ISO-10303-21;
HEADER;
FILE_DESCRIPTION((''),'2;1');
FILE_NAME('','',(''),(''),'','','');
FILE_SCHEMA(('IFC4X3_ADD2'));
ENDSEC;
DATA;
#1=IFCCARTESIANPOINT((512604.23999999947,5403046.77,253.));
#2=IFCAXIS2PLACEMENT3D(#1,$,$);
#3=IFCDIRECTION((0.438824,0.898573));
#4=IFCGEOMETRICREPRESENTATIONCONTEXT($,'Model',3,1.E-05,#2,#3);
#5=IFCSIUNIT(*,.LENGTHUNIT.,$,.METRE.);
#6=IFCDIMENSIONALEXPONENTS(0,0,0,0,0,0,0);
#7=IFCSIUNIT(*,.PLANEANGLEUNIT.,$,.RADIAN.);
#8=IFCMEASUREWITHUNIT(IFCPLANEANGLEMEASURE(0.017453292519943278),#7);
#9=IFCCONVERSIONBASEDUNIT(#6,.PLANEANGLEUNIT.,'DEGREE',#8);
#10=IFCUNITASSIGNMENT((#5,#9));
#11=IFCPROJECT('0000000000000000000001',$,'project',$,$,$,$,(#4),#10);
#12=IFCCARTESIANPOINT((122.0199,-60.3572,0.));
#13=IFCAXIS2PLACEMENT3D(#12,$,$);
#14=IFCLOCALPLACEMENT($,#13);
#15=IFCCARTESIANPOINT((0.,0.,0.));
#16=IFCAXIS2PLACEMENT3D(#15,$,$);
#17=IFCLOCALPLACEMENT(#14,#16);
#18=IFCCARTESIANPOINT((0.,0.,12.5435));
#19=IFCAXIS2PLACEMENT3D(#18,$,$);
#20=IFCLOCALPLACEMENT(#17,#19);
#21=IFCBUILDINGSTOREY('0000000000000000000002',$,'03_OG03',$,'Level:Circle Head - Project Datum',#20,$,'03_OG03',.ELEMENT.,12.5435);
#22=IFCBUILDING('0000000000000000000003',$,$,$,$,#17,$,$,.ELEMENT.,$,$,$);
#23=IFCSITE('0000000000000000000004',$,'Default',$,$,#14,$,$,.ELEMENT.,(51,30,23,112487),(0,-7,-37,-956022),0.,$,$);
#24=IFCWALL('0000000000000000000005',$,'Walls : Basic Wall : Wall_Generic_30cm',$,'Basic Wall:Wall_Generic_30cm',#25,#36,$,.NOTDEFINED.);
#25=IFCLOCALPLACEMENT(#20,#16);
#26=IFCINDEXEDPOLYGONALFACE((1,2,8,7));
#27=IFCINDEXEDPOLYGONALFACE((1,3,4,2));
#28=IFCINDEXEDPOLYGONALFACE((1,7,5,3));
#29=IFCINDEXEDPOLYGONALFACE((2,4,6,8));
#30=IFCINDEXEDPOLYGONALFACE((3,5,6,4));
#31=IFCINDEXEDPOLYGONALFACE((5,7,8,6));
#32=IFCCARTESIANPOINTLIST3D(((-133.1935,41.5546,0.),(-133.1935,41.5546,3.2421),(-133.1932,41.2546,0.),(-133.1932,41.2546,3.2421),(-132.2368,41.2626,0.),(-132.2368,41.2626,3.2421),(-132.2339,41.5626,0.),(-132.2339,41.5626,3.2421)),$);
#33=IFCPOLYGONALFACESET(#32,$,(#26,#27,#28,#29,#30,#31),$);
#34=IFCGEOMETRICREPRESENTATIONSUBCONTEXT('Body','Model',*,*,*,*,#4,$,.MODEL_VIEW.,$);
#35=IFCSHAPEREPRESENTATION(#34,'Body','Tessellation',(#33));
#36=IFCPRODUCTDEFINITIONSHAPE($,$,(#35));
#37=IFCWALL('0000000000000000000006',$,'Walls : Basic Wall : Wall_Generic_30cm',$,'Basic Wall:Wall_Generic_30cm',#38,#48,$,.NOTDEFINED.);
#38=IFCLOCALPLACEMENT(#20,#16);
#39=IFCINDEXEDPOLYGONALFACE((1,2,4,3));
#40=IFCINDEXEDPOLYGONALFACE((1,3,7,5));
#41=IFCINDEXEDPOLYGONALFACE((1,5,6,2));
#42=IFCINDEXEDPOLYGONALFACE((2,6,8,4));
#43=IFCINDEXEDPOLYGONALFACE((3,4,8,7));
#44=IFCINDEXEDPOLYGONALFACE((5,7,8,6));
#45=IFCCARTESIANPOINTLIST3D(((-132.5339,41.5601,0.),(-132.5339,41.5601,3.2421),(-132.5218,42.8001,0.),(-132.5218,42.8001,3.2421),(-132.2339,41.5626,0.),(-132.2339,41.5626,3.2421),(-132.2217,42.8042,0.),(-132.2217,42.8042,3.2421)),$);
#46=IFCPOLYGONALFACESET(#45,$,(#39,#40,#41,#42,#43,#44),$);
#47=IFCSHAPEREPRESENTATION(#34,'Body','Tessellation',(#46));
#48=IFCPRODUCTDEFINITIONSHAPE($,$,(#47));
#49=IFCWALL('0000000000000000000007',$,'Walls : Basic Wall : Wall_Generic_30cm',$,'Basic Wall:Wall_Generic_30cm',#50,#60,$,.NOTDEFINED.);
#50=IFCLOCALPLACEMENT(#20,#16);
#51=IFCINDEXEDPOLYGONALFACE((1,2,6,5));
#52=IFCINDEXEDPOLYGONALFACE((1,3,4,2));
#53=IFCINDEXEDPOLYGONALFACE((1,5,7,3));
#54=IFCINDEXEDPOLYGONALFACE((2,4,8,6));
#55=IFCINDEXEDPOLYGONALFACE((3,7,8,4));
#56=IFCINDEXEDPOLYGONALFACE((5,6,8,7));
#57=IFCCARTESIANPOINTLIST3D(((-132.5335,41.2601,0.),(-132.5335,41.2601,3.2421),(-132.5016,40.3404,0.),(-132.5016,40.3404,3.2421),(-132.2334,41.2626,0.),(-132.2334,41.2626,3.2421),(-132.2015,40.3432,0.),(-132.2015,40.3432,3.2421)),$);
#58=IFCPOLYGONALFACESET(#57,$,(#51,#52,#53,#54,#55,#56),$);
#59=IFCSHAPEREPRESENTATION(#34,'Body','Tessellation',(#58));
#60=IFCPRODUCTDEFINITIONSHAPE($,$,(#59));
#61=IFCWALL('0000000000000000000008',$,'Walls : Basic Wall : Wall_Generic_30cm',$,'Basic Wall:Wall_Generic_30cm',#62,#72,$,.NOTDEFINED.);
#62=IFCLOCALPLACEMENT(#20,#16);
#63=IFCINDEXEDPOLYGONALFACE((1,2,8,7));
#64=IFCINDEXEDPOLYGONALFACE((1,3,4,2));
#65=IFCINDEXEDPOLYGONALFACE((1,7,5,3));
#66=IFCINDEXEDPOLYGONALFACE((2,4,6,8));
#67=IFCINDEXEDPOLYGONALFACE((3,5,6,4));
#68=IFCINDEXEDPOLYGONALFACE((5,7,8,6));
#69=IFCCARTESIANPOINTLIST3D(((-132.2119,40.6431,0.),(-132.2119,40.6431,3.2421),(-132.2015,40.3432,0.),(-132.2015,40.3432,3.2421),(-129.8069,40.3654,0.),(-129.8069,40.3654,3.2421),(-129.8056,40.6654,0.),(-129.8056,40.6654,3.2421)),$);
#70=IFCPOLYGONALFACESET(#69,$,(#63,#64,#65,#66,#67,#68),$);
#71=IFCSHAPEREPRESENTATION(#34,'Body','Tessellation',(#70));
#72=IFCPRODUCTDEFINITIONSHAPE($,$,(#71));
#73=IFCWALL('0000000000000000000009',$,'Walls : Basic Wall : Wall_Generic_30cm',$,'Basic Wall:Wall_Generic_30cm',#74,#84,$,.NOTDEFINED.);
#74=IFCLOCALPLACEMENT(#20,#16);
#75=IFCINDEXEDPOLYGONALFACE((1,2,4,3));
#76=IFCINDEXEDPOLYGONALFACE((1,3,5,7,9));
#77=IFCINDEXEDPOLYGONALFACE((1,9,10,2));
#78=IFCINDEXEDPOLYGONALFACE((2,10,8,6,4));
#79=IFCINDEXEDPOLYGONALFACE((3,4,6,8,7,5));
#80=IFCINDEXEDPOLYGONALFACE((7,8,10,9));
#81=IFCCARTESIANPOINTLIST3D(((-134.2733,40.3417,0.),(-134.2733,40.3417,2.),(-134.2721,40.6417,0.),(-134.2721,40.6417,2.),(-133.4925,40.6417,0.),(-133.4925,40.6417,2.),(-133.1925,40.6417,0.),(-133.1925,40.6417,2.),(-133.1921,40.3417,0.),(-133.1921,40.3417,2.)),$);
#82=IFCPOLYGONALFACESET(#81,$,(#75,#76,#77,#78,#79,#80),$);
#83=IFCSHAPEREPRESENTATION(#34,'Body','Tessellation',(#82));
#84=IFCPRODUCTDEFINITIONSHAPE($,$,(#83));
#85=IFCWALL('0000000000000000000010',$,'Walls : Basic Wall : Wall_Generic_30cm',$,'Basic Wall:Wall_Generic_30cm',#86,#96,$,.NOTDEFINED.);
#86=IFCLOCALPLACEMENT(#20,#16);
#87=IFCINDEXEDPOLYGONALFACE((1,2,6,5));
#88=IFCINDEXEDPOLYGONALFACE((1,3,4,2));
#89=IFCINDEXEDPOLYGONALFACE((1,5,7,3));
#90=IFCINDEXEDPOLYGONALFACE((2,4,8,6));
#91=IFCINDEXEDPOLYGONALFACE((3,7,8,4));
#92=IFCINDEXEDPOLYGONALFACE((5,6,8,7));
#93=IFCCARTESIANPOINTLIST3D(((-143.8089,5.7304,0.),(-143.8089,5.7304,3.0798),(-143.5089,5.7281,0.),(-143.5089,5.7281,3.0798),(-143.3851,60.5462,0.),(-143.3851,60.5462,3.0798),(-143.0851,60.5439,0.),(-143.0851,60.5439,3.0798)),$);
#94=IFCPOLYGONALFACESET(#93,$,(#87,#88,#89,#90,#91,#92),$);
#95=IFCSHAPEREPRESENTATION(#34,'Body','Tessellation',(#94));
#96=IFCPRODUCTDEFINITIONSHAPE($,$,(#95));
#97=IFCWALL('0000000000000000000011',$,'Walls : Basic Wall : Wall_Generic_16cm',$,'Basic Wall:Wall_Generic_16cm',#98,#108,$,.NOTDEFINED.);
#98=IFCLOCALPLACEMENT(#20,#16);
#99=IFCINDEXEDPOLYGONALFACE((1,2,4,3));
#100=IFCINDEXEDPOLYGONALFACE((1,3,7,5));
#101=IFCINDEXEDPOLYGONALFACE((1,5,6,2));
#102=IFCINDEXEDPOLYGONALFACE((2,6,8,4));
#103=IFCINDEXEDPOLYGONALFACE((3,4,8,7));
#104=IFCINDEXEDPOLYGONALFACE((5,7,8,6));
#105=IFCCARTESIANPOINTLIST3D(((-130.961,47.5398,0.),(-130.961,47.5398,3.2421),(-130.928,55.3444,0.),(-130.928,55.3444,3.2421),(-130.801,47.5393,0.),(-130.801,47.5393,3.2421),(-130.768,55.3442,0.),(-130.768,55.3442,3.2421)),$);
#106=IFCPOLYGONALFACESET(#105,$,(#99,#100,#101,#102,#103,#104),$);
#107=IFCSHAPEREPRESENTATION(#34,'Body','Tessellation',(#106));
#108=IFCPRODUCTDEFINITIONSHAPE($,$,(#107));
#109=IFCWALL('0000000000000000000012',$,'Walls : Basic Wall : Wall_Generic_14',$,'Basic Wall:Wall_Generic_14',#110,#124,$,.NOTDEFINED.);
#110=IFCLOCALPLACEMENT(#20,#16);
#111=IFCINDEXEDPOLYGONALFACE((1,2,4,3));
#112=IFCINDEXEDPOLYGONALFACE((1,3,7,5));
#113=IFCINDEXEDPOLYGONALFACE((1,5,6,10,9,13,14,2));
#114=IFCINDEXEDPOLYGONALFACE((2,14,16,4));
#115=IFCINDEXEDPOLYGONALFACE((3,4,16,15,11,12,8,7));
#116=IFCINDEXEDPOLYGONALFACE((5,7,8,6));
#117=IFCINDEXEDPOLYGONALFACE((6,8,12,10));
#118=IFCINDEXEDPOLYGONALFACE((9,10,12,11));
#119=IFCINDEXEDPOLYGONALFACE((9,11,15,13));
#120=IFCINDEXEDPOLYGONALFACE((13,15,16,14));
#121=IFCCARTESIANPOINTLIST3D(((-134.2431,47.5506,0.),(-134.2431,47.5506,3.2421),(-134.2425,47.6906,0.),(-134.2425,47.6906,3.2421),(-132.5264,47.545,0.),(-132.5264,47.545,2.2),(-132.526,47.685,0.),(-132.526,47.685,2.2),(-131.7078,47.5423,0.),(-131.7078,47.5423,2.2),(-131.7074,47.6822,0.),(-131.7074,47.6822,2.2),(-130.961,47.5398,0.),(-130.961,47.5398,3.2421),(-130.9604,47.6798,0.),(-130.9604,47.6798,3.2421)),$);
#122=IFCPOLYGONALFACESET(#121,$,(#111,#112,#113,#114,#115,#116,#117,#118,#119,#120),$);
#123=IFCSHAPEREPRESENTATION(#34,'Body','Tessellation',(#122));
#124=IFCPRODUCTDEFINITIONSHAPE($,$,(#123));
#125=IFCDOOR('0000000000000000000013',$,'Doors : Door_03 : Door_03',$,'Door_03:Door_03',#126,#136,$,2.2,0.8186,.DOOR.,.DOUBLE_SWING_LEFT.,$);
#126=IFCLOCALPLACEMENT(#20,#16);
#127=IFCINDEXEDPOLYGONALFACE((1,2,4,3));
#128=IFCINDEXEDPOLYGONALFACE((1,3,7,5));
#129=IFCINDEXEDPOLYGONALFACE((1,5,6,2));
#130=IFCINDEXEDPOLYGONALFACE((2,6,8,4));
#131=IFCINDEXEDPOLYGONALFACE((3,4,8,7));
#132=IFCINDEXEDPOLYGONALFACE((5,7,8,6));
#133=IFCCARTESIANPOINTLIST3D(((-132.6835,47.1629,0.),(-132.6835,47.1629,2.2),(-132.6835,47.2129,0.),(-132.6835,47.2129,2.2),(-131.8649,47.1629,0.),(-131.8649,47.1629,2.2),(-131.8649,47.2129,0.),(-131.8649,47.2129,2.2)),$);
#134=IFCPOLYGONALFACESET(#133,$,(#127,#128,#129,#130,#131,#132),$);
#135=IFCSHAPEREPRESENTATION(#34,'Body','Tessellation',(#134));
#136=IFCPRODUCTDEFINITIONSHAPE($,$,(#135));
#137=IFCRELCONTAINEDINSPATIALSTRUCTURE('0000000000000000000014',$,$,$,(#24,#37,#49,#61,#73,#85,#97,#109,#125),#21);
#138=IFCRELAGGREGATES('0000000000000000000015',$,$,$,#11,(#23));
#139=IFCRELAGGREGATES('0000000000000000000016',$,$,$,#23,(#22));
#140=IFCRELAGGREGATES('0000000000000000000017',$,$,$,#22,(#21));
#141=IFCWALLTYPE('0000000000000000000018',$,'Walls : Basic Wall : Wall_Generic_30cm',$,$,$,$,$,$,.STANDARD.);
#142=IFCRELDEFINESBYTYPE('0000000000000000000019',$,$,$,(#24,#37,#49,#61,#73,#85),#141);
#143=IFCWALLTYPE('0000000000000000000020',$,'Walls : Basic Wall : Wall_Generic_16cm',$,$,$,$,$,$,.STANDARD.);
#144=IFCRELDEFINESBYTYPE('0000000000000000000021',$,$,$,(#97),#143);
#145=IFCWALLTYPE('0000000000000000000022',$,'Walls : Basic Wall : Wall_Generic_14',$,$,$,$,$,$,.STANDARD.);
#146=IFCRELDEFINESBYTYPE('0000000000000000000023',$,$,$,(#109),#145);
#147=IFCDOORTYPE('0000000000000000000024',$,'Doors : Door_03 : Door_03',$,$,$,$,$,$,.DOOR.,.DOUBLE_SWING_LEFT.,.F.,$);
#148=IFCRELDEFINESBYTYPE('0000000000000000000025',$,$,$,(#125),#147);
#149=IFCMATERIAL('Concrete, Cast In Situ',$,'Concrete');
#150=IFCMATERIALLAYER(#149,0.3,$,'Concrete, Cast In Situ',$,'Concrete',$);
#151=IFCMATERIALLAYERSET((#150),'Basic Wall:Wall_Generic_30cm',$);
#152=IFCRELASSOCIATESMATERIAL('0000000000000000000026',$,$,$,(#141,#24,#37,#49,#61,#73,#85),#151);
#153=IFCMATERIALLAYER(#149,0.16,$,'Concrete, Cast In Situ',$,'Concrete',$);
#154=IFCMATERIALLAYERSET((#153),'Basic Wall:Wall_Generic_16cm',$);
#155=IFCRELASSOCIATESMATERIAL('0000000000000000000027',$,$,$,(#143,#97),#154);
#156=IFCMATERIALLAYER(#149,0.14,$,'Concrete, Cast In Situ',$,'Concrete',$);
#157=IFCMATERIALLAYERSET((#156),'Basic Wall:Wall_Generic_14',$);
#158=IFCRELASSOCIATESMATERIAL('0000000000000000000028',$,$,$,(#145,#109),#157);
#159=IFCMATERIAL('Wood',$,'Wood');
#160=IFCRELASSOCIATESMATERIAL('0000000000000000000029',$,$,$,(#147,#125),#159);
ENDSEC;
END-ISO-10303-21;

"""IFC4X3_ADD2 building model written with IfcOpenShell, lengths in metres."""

from ifc_helpers import new_model, entity, si_unit, converted_unit, direction, frame, frame_2d, origin, origin_2d_with_axis, place, context, subcontext, project, spatial, polyline, rectangle, outline, extrude, clip, halfspace, bounded_halfspace, source, transform, mapped, material, layer, layer_set, type_object, type_shapes, element, fill, save


model = new_model("IFC4X3_ADD2")

# Units and contexts
model_context = context("Model", 3, precision=1e-05, world=frame((512604.23999999947, 5403046.77, 253.0)), true_north=direction((0.438824, 0.898573)))
body_context = subcontext(model_context, "Body", "Model", "MODEL_VIEW")
ifc_project = project(units=[si_unit("LENGTHUNIT", "METRE"), converted_unit("PLANEANGLEUNIT", "DEGREE", entity("IfcPlaneAngleMeasure", 0.017453292519943278), si_unit("PLANEANGLEUNIT", "RADIAN"), dimensions=[0, 0, 0, 0, 0, 0, 0])], contexts=[model_context])

# Site, building, storey
site_placement = place(None, frame((122.0199, -60.3572, 0.0)))
site = spatial("IfcSite", under=ifc_project, at=site_placement, Name="Default", CompositionType="ELEMENT", RefLatitude=(51, 30, 23, 112487), RefLongitude=(0, -7, -37, -956022), RefElevation=0.0)
building_placement = place(site_placement, origin())
building = spatial("IfcBuilding", under=site, at=building_placement, CompositionType="ELEMENT")
storey_placement = place(building_placement, frame((0.0, 0.0, 12.5435)))
storey = spatial("IfcBuildingStorey", under=building, at=storey_placement, Name="03_OG03", ObjectType="Level:Circle Head - Project Datum", LongName="03_OG03", CompositionType="ELEMENT", Elevation=12.5435)

# Walls
ifc_material_1 = material(Name="Concrete, Cast In Situ", Category="Concrete")
ifc_layer_1 = layer(ifc_material_1, 0.3, Name="Concrete, Cast In Situ", Category="Concrete")
ifc_layer_set_1 = layer_set([ifc_layer_1], Name="Basic Wall:Wall_Generic_30cm")
wall_type_1 = type_object("IfcWallType", Name="Walls : Basic Wall : Wall_Generic_30cm", PredefinedType="STANDARD", material=ifc_layer_set_1)
wall_1_placement = place(storey_placement, frame((-133.1945, 41.4046, 0.0), z_axis=(0.0, 0.0, 1.0), x_axis=(0.999965, 0.008418, 0.0)))
element("IfcWall", 1, at=wall_1_placement, inside=storey, type_object=wall_type_1, material=ifc_layer_set_1, Name="Walls : Basic Wall : Wall_Generic_30cm", ObjectType="Basic Wall:Wall_Generic_30cm", PredefinedType="NOTDEFINED", context=body_context, shape_type="Clipping", body=[
    clip(extrude(outline(polyline([(0.9564, -0.15), (0.9618, 0.15), (0.6618, 0.15), (0.0022, 0.15), (0.0, -0.15), (0.6597, -0.15), (0.9564, -0.15)])), origin(), (0.0, 0.0, 1.0), 3.2421), bounded_halfspace(frame((0.0, -0.15, 3.2421), z_axis=(0.0, 0.0, -1.0), x_axis=(-0.011256, -0.999937, 0.0)), True, frame((0.0, -0.15, 3.2421)), polyline([(0.0, 0.0), (0.6597, 0.0), (0.9564, 0.0), (0.9618, 0.3), (0.6618, 0.3), (0.0022, 0.3), (0.0, 0.0)]))),
])
wall_2_placement = place(storey_placement, frame((-132.384, 41.5587, 0.0), z_axis=(0.0, 0.0, 1.0), x_axis=(0.009813, 0.999952, 0.0)))
element("IfcWall", 2, at=wall_2_placement, inside=storey, type_object=wall_type_1, material=ifc_layer_set_1, Name="Walls : Basic Wall : Wall_Generic_30cm", ObjectType="Basic Wall:Wall_Generic_30cm", PredefinedType="NOTDEFINED", context=body_context, shape_type="Clipping", body=[
    clip(extrude(outline(polyline([(1.2471, -0.15), (1.24, 0.15), (0.0, 0.15), (0.0055, -0.15), (1.2471, -0.15)])), origin(), (0.0, 0.0, 1.0), 3.2421), bounded_halfspace(frame((0.0055, -0.15, 3.2421), z_axis=(0.0, 0.0, -1.0), x_axis=(-0.999976, -0.006976, 0.0)), True, frame((0.0055, -0.15, 3.2421)), polyline([(0.0, 0.0), (1.2416, 0.0), (1.2345, 0.3), (-0.0055, 0.3), (0.0, 0.0)]))),
])
wall_3_placement = place(storey_placement, frame((-132.3836, 41.2653, 0.0), z_axis=(0.0, 0.0, 1.0), x_axis=(0.034652, -0.999399, 0.0)))
element("IfcWall", 3, at=wall_3_placement, inside=storey, type_object=wall_type_1, material=ifc_layer_set_1, Name="Walls : Basic Wall : Wall_Generic_30cm", ObjectType="Basic Wall:Wall_Generic_30cm", PredefinedType="NOTDEFINED", context=body_context, shape_type="Clipping", body=[
    clip(extrude(outline(polyline([(0.9203, -0.15), (0.9279, 0.15), (0.6278, 0.15), (0.0079, 0.15), (0.0078, 0.1466), (0.0, -0.15), (0.9203, -0.15)])), origin(), (0.0, 0.0, 1.0), 3.2421), bounded_halfspace(frame((0.0, -0.15, 3.2421), z_axis=(0.0, 0.0, -1.0), x_axis=(0.999297, -0.037488, 0.0)), True, frame((0.0, -0.15, 3.2421)), polyline([(0.0, 0.0), (0.9203, 0.0), (0.9279, 0.3), (0.6278, 0.3), (0.0079, 0.3), (0.0078, 0.2966), (0.0, 0.0)]))),
])
wall_4_placement = place(storey_placement, frame((-132.2105, 40.4931, 0.0), z_axis=(0.0, 0.0, 1.0), x_axis=(0.999957, 0.00927, 0.0)))
element("IfcWall", 4, at=wall_4_placement, inside=storey, type_object=wall_type_1, material=ifc_layer_set_1, Name="Walls : Basic Wall : Wall_Generic_30cm", ObjectType="Basic Wall:Wall_Generic_30cm", PredefinedType="NOTDEFINED", context=body_context, shape_type="Clipping", body=[
    clip(extrude(outline(polyline([(2.4024, -0.15), (2.4064, 0.15), (0.0, 0.15), (0.0076, -0.15), (2.4024, -0.15)])), origin(), (0.0, 0.0, 1.0), 3.2421), bounded_halfspace(frame((0.0076, -0.15, 3.2421), z_axis=(0.0, 0.0, -1.0), x_axis=(-0.012107, -0.999927, 0.0)), True, frame((0.0076, -0.15, 3.2421)), polyline([(0.0, 0.0), (2.3947, 0.0), (2.3988, 0.3), (-0.0076, 0.3), (0.0, 0.0)]))),
])
wall_5_placement = place(storey_placement, frame((-133.1921, 40.4917, 0.0), z_axis=(0.0, 0.0, 1.0), x_axis=(-1.0, 0.0, 0.0)))
element("IfcWall", 5, at=wall_5_placement, inside=storey, type_object=wall_type_1, material=ifc_layer_set_1, Name="Walls : Basic Wall : Wall_Generic_30cm", ObjectType="Basic Wall:Wall_Generic_30cm", PredefinedType="NOTDEFINED", context=body_context, shape_type="SweptSolid", body=[
    extrude(outline(polyline([(1.0799, -0.15), (1.0812, 0.15), (0.0, 0.15), (0.0004, -0.15), (0.3004, -0.15), (1.0799, -0.15)])), origin(), (0.0, 0.0, 1.0), 2.0),
])
wall_6_placement = place(storey_placement, frame((-143.2351, 60.5451, 0.0), z_axis=(0.0, 0.0, 1.0), x_axis=(-0.007732, -0.99997, 0.0)))
element("IfcWall", 6, at=wall_6_placement, inside=storey, type_object=wall_type_1, material=ifc_layer_set_1, Name="Walls : Basic Wall : Wall_Generic_30cm", ObjectType="Basic Wall:Wall_Generic_30cm", PredefinedType="NOTDEFINED", context=body_context, shape_type="Clipping", body=[
    clip(extrude(rectangle(XDim=54.8174, YDim=0.3, at=frame_2d((27.4087, 0.0), x_axis=(-1.0, 0.0))), origin(), (0.0, 0.0, 1.0), 3.0798), halfspace(frame((0.0, 0.0, -12.5435)), True)),
])
ifc_layer_2 = layer(ifc_material_1, 0.16, Name="Concrete, Cast In Situ", Category="Concrete")
ifc_layer_set_2 = layer_set([ifc_layer_2], Name="Basic Wall:Wall_Generic_16cm")
wall_type_2 = type_object("IfcWallType", Name="Walls : Basic Wall : Wall_Generic_16cm", PredefinedType="STANDARD", material=ifc_layer_set_2)
wall_7_placement = place(storey_placement, frame((-130.848, 55.3446, 0.0), z_axis=(0.0, 0.0, 1.0), x_axis=(-0.004226, -0.999991, 0.0)))
element("IfcWall", 7, at=wall_7_placement, inside=storey, type_object=wall_type_2, material=ifc_layer_set_2, Name="Walls : Basic Wall : Wall_Generic_16cm", ObjectType="Basic Wall:Wall_Generic_16cm", PredefinedType="NOTDEFINED", context=body_context, shape_type="Clipping", body=[
    clip(extrude(outline(polyline([(7.8052, -0.08), (7.805, 0.08), (0.0, 0.08), (0.0005, -0.08), (7.6652, -0.08), (7.8052, -0.08)])), origin(), (0.0, 0.0, 1.0), 3.2421), bounded_halfspace(frame((0.0005, -0.08, 3.2421), z_axis=(0.0, 0.0, -1.0), x_axis=(0.999999, 0.001389, 0.0)), True, frame((0.0005, -0.08, 3.2421)), polyline([(0.0, 0.0), (7.6647, 0.0), (7.8047, 0.0), (7.8045, 0.16), (-0.0005, 0.16), (0.0, 0.0)]))),
])

# Wall, opening, door
ifc_layer_3 = layer(ifc_material_1, 0.14, Name="Concrete, Cast In Situ", Category="Concrete")
ifc_layer_set_3 = layer_set([ifc_layer_3], Name="Basic Wall:Wall_Generic_14")
wall_type_3 = type_object("IfcWallType", Name="Walls : Basic Wall : Wall_Generic_14", PredefinedType="STANDARD", material=ifc_layer_set_3)
wall_8_placement = place(storey_placement, frame((-130.9606, 47.6098, 0.0), z_axis=(0.0, 0.0, 1.0), x_axis=(-0.999995, 0.003304, 0.0)))
wall_8 = element("IfcWall", 8, at=wall_8_placement, inside=storey, type_object=wall_type_3, material=ifc_layer_set_3, Name="Walls : Basic Wall : Wall_Generic_14", ObjectType="Basic Wall:Wall_Generic_14", PredefinedType="NOTDEFINED", context=body_context, shape_type="Clipping", body=[
    clip(extrude(outline(polyline([(0.0, -0.07), (3.2821, -0.07), (3.2822, 0.07), (0.0001, 0.07), (0.0, -0.07)])), origin(), (0.0, 0.0, 1.0), 3.2421), bounded_halfspace(frame((0.0, -0.07, 3.2421), z_axis=(0.0, 0.0, -1.0), x_axis=(-0.000467, 1.0, 0.0)), True, frame((0.0, -0.07, 3.2421)), polyline([(0.0, 0.0), (3.2821, 0.0), (3.2822, 0.14), (0.0001, 0.14), (0.0, 0.0)]))),
])
opening_placement = place(wall_8_placement, frame((-131.1172, 47.1768, 0.0), z_axis=(0.0, 0.0, 1.0), x_axis=(-0.999995, -0.003304, 0.0)))
opening = element("IfcOpeningElement", 9, at=opening_placement, cuts=wall_8, PredefinedType="OPENING", context=body_context, shape_type="SweptSolid", body=[
    extrude(rectangle(XDim=2.2, YDim=0.8186, at=frame_2d((0.0, 0.0), x_axis=(1.0, 0.0))), frame((-132.1167, 47.6836, 1.1), z_axis=(-0.003304, -0.999995, 0.0), x_axis=(0.0, 0.0, -1.0)), (0.0, 0.0, 1.0), 0.14),
])
ifc_material_2 = material(Name="Wood", Category="Wood")
door_type = type_object("IfcDoorType", Name="Doors : Door_03 : Door_03", OperationType="DOUBLE_SWING_LEFT", ParameterTakesPrecedence=False, PredefinedType="DOOR", material=ifc_material_2)
shared_shape_1 = source(origin(), body_context, "Body", "SweptSolid", [
    extrude(rectangle(XDim=0.8186, YDim=0.05, at=origin_2d_with_axis()), frame((0.4093, 0.2159, 0.0)), (0.0, 0.0, 1.0), 2.2),
])
type_shapes(door_type, [shared_shape_1])
door_placement = place(opening_placement, frame((-132.6835, 46.972, 0.0)))
door = element("IfcDoor", 10, at=door_placement, inside=storey, type_object=door_type, material=ifc_material_2, Name="Doors : Door_03 : Door_03", ObjectType="Door_03:Door_03", OperationType="DOUBLE_SWING_LEFT", OverallHeight=2.2, OverallWidth=0.8186, PredefinedType="DOOR", context=body_context, shape_type="MappedRepresentation", body=[
    mapped(shared_shape_1, transform((0.0, 0.0, 0.0), scale=1.0)),
])
fill(opening, door)

save(model, "model.ifc")
